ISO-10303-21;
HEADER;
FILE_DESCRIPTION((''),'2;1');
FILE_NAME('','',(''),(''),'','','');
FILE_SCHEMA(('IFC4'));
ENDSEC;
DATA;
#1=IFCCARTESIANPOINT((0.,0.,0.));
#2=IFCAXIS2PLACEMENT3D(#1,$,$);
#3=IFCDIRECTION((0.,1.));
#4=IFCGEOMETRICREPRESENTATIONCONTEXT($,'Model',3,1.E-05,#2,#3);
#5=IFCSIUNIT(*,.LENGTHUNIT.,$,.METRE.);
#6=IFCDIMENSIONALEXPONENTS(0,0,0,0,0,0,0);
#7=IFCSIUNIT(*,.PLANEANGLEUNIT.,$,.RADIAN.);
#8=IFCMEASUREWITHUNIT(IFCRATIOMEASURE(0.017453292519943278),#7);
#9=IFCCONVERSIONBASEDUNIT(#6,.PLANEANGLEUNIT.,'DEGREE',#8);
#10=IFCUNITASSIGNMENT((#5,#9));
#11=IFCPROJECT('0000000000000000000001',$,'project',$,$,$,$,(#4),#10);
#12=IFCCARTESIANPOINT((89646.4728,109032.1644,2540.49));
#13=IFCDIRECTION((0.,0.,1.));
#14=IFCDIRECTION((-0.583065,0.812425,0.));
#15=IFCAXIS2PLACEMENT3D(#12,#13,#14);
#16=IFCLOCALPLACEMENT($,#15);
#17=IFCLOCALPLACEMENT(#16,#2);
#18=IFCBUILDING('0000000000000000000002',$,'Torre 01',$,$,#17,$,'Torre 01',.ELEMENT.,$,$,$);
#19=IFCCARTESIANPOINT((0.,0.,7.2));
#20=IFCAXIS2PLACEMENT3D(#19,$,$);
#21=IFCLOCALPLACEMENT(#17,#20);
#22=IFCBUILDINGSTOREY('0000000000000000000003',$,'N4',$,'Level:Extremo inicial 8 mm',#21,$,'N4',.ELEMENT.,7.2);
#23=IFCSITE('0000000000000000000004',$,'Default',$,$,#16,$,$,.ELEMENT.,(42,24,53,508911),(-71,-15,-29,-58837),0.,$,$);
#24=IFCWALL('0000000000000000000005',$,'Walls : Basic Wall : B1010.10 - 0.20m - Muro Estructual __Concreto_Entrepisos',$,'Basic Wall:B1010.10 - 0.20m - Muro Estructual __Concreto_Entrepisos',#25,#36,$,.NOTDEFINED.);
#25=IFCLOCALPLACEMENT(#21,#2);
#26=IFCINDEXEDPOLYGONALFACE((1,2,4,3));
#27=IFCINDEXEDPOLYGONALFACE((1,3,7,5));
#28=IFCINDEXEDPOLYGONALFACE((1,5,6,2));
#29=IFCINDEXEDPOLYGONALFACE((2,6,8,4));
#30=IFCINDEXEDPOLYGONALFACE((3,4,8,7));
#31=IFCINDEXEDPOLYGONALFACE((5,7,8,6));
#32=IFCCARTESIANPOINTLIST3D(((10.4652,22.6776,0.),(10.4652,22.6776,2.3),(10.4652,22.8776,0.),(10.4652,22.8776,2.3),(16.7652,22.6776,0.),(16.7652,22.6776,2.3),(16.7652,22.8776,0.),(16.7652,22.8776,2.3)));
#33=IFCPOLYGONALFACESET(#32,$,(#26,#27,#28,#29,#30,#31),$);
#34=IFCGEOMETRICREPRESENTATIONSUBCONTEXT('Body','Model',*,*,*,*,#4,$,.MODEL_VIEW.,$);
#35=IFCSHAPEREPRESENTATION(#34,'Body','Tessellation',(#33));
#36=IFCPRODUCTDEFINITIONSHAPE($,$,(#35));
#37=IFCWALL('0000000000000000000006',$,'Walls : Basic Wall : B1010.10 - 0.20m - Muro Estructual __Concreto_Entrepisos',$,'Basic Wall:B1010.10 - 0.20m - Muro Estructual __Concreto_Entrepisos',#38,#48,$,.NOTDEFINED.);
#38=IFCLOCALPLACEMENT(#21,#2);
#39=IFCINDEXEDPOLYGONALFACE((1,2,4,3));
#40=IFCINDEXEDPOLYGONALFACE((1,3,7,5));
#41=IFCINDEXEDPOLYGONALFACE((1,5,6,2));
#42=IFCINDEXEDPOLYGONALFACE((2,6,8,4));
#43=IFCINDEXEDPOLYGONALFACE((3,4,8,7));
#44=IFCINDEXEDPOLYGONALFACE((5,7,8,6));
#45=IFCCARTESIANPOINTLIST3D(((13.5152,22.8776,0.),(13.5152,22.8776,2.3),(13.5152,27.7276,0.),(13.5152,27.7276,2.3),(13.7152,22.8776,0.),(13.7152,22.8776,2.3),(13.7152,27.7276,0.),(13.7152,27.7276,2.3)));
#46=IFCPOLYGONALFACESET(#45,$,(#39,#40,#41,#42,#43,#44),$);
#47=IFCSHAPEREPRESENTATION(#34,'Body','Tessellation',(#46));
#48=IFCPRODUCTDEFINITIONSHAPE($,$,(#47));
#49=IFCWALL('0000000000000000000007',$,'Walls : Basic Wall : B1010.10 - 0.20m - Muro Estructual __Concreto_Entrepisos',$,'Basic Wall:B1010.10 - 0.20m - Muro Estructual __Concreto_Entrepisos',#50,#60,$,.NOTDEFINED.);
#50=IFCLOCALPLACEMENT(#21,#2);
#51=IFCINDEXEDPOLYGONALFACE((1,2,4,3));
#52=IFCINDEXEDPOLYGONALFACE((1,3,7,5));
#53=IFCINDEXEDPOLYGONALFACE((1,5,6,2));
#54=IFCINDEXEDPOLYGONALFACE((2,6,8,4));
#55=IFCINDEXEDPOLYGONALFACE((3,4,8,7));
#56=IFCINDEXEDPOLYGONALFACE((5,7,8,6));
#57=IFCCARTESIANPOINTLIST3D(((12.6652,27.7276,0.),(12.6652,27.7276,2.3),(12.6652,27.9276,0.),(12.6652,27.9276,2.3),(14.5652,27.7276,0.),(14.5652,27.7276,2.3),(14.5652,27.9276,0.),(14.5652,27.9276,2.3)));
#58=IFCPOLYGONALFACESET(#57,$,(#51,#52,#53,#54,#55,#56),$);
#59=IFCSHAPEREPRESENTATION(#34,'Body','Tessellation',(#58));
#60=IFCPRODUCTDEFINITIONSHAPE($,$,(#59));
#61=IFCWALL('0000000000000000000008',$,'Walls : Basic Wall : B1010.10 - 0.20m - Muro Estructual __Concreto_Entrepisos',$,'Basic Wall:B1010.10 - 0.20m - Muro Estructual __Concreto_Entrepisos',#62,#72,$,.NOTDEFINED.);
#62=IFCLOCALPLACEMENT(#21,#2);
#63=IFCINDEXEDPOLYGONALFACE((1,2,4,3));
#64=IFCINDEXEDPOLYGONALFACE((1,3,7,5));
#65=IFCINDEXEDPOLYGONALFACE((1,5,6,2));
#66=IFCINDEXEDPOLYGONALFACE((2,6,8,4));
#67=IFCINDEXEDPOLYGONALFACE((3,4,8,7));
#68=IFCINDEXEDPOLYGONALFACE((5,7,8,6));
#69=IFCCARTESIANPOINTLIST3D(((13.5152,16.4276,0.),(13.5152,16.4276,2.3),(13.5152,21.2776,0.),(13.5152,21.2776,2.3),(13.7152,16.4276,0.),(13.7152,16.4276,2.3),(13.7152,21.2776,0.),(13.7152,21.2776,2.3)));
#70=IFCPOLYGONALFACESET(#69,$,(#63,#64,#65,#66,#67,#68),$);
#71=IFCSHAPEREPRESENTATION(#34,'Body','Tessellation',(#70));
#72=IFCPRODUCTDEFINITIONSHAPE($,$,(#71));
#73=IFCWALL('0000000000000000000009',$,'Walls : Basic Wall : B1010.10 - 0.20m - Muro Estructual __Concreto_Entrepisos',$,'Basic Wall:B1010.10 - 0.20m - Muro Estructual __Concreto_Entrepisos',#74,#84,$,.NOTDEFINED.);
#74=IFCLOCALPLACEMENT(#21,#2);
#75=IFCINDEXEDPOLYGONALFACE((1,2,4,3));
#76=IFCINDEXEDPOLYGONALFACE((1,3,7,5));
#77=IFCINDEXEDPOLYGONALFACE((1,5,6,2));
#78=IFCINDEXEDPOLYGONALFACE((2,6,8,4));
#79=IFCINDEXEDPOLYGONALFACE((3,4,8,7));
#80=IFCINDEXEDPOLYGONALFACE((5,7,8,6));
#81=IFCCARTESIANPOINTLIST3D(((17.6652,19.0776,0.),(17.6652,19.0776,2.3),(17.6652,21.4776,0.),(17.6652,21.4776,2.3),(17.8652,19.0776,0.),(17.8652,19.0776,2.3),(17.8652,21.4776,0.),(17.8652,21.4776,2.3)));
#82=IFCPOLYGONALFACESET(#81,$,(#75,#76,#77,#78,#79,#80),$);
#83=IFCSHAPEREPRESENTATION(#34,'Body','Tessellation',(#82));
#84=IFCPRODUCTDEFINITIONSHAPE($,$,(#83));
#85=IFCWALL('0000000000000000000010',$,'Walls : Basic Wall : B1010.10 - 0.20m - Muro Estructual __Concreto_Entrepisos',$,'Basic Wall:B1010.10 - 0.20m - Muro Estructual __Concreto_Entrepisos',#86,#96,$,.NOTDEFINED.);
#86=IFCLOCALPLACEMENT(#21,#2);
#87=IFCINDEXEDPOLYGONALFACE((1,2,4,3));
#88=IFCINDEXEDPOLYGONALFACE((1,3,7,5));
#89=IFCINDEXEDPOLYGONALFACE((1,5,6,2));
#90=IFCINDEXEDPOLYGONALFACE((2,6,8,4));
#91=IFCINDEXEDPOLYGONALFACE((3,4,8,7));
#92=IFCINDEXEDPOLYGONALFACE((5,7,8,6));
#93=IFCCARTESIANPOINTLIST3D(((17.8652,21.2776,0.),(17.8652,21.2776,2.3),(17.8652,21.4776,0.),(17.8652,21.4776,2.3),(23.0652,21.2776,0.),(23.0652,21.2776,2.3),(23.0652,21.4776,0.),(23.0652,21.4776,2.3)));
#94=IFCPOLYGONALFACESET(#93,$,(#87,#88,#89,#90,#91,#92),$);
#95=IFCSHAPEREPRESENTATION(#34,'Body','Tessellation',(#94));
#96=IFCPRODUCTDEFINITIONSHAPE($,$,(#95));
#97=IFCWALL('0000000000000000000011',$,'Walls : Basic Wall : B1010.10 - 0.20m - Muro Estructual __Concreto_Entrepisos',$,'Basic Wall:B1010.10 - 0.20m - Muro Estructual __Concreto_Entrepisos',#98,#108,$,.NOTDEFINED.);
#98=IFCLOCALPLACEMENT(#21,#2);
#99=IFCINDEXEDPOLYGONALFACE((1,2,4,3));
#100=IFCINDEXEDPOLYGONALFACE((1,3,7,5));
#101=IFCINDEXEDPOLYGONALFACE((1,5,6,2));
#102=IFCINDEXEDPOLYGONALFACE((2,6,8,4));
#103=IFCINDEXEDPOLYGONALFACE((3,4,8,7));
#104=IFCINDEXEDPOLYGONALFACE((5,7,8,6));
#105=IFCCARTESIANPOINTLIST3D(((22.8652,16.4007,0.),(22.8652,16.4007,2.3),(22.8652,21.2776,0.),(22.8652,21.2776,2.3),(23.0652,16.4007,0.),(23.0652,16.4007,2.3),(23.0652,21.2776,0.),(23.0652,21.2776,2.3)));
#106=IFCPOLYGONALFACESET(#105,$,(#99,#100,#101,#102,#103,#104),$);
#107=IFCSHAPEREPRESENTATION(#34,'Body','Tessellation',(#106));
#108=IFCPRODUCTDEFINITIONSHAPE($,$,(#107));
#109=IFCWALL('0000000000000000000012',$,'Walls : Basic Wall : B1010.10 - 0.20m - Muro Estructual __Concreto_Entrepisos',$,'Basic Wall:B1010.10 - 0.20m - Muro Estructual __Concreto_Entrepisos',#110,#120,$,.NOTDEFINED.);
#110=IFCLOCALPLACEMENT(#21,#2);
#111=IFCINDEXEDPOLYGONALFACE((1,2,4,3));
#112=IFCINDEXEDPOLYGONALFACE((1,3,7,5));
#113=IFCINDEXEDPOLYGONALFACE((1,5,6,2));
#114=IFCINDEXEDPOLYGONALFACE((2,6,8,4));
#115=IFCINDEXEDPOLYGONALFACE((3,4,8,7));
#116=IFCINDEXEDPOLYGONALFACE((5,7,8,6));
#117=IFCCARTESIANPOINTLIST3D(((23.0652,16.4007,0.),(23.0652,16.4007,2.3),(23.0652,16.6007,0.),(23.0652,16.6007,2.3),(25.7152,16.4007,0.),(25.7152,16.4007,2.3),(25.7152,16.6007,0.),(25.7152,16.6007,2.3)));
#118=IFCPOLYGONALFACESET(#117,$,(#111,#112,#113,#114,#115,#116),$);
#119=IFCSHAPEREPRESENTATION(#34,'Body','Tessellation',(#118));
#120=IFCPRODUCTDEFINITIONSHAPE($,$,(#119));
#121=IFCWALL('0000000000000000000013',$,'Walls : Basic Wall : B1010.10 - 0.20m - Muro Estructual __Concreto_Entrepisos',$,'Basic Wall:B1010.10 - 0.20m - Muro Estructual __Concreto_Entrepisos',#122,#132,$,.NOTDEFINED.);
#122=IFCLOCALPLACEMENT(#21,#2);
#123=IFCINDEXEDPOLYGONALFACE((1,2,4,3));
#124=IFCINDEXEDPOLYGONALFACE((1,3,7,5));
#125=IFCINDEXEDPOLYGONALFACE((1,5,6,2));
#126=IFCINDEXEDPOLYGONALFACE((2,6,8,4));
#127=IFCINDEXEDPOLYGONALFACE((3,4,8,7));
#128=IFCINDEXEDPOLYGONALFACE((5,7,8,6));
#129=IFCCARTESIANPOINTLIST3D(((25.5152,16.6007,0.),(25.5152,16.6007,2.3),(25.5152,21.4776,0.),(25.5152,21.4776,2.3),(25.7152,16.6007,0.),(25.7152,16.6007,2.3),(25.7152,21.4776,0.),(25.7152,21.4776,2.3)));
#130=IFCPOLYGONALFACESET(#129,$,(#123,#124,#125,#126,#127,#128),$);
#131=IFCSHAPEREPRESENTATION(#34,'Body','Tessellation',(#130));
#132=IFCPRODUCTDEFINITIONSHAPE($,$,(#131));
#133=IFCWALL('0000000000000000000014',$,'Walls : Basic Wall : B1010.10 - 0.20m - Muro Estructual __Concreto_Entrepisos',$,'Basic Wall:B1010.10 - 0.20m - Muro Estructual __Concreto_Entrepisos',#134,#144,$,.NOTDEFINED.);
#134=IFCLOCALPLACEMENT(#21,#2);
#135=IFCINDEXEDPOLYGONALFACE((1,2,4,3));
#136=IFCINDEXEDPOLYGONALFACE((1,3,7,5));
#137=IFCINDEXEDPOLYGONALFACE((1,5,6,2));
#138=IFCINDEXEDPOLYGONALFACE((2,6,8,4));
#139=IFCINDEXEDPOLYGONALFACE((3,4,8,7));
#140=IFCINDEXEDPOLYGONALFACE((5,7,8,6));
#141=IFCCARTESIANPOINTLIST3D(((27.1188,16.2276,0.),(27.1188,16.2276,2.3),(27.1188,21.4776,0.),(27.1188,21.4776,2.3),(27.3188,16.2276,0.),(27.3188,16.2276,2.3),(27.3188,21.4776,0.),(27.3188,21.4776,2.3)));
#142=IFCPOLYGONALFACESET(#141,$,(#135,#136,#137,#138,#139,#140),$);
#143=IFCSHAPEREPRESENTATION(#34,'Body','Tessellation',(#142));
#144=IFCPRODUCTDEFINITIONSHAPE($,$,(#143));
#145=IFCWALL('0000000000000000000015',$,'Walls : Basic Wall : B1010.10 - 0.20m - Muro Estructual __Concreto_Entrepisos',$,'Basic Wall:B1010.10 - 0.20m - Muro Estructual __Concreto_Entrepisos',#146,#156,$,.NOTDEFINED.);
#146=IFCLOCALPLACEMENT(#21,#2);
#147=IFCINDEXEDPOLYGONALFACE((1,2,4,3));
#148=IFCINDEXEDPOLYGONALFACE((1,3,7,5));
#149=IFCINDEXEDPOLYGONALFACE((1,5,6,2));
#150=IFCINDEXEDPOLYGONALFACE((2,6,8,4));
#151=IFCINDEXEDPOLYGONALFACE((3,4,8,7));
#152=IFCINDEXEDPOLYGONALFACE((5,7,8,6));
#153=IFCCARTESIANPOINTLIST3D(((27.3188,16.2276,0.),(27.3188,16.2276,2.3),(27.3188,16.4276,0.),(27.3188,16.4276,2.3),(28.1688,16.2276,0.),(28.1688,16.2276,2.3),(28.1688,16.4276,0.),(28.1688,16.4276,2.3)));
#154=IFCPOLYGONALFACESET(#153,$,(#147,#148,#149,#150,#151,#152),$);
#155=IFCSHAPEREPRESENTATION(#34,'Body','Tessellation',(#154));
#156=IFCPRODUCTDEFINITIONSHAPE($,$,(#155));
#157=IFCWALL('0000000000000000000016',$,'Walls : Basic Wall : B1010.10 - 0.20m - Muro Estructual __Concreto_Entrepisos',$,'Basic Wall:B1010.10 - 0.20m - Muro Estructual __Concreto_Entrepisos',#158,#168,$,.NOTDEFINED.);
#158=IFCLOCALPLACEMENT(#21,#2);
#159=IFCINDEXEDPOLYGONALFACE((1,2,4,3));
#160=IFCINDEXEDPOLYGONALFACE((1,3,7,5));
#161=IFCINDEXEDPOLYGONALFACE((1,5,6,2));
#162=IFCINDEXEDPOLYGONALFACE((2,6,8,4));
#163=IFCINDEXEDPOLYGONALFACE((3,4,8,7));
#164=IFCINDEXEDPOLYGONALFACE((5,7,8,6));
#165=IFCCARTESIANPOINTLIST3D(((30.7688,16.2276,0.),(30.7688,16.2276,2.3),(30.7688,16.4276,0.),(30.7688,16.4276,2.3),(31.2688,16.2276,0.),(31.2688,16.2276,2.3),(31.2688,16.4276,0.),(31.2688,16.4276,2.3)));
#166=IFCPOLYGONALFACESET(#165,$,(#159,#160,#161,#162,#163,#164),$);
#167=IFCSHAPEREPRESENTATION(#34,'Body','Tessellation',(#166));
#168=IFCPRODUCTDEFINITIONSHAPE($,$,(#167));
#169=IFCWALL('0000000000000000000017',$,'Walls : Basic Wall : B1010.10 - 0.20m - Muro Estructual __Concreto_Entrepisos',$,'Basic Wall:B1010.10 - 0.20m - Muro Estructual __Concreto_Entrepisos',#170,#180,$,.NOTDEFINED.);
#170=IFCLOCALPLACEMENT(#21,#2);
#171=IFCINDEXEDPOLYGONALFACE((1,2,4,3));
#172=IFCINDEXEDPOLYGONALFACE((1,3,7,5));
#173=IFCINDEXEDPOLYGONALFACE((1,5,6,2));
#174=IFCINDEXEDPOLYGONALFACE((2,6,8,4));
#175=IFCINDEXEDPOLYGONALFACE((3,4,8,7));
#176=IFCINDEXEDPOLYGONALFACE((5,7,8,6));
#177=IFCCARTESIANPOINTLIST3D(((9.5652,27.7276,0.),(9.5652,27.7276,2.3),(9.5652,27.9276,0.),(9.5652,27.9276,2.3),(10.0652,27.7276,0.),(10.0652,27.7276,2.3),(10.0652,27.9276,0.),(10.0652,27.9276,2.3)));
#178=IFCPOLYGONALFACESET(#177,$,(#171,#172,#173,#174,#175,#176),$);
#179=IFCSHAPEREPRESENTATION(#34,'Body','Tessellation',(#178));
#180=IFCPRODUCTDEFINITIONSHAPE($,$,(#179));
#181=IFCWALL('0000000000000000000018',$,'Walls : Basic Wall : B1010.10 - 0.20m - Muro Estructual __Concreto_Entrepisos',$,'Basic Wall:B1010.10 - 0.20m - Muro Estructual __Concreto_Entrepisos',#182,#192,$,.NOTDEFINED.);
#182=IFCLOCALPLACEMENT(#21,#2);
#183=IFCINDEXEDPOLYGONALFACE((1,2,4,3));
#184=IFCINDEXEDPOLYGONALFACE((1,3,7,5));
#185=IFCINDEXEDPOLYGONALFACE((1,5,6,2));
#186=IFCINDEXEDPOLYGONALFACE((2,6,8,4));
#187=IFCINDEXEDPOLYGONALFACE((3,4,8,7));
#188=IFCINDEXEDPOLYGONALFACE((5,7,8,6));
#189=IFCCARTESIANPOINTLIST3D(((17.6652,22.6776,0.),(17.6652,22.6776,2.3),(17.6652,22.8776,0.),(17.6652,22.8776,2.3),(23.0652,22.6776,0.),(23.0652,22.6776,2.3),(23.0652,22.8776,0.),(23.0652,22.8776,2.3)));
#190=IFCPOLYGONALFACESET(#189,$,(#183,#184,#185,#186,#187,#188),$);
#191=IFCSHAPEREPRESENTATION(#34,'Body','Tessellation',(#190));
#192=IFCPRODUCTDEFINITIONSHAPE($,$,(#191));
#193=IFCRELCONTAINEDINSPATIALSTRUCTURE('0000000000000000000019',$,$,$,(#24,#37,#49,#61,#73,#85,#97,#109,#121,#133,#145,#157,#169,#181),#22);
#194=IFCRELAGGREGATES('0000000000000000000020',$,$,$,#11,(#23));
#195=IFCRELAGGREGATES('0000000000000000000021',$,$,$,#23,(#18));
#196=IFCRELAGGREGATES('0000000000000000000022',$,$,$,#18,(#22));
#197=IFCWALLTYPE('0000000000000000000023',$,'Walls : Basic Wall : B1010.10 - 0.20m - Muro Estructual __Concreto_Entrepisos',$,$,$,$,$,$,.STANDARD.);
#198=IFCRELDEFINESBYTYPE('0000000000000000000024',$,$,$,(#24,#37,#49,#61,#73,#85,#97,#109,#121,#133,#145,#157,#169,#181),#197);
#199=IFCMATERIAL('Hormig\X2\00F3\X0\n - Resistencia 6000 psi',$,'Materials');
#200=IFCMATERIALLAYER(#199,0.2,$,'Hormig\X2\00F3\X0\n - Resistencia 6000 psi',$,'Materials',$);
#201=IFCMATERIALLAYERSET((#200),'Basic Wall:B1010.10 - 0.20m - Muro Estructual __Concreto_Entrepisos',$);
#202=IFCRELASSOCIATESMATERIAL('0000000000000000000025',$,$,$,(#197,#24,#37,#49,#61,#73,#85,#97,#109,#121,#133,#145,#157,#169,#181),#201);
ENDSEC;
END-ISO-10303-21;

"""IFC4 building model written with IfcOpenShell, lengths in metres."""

from ifc_helpers import new_model, entity, si_unit, converted_unit, direction, frame, frame_2d, origin, place, context, subcontext, project, spatial, rectangle, extrude, material, layer, layer_set, layer_usage, type_object, element, save


model = new_model("IFC4")

# Units and contexts
model_context = context("Model", 3, precision=1e-05, world=origin(), true_north=direction((0.0, 1.0)))
body_context = subcontext(model_context, "Body", "Model", "MODEL_VIEW")
ifc_project = project(units=[si_unit("LENGTHUNIT", "METRE"), converted_unit("PLANEANGLEUNIT", "DEGREE", entity("IfcRatioMeasure", 0.017453292519943278), si_unit("PLANEANGLEUNIT", "RADIAN"), dimensions=[0, 0, 0, 0, 0, 0, 0])], contexts=[model_context])

# Site, building, storey
site_placement = place(None, frame((89646.4728, 109032.1644, 2540.49), z_axis=(0.0, 0.0, 1.0), x_axis=(-0.583065, 0.812425, 0.0)))
site = spatial("IfcSite", under=ifc_project, at=site_placement, Name="Default", CompositionType="ELEMENT", RefLatitude=(42, 24, 53, 508911), RefLongitude=(-71, -15, -29, -58837), RefElevation=0.0)
building_placement = place(site_placement, origin())
building = spatial("IfcBuilding", under=site, at=building_placement, Name="Torre 01", LongName="Torre 01", CompositionType="ELEMENT")
storey_placement = place(building_placement, frame((0.0, 0.0, 7.2)))
storey = spatial("IfcBuildingStorey", under=building, at=storey_placement, Name="N4", ObjectType="Level:Extremo inicial 8 mm", LongName="N4", CompositionType="ELEMENT", Elevation=7.2)

# Walls
ifc_material = material(Name="Hormigón - Resistencia 6000 psi", Category="Materials")
ifc_layer_1 = layer(ifc_material, 0.2, Name="Hormigón - Resistencia 6000 psi", Category="Materials")
ifc_layer_set_1 = layer_set([ifc_layer_1], Name="Basic Wall:B1010.10 - 0.20m - Muro Estructual __Concreto_Entrepisos")
ifc_layer_usage_1 = layer_usage(ifc_layer_set_1, "AXIS2", "NEGATIVE", 0.1)
wall_type_1 = type_object("IfcWallType", Name="Walls : Basic Wall : B1010.10 - 0.20m - Muro Estructual __Concreto_Entrepisos", PredefinedType="STANDARD", material=ifc_layer_set_1)
wall_1_placement = place(storey_placement, frame((10.4652, 22.7776, 0.0)))
element("IfcWall", 1, at=wall_1_placement, inside=storey, type_object=wall_type_1, material=ifc_layer_usage_1, Name="Walls : Basic Wall : B1010.10 - 0.20m - Muro Estructual __Concreto_Entrepisos", ObjectType="Basic Wall:B1010.10 - 0.20m - Muro Estructual __Concreto_Entrepisos", PredefinedType="NOTDEFINED", context=body_context, shape_type="SweptSolid", body=[
    extrude(rectangle(XDim=6.3, YDim=0.2, at=frame_2d((3.15, 0.0), x_axis=(-1.0, 0.0))), origin(), (0.0, 0.0, 1.0), 2.3),
])
ifc_layer_usage_2 = layer_usage(ifc_layer_set_1, "AXIS2", "NEGATIVE", 0.1)
wall_2_placement = place(storey_placement, frame((13.6152, 22.8776, 0.0), z_axis=(0.0, 0.0, 1.0), x_axis=(0.0, 1.0, 0.0)))
element("IfcWall", 2, at=wall_2_placement, inside=storey, type_object=wall_type_1, material=ifc_layer_usage_2, Name="Walls : Basic Wall : B1010.10 - 0.20m - Muro Estructual __Concreto_Entrepisos", ObjectType="Basic Wall:B1010.10 - 0.20m - Muro Estructual __Concreto_Entrepisos", PredefinedType="NOTDEFINED", context=body_context, shape_type="SweptSolid", body=[
    extrude(rectangle(XDim=4.85, YDim=0.2, at=frame_2d((2.425, 0.0), x_axis=(-1.0, 0.0))), origin(), (0.0, 0.0, 1.0), 2.3),
])
ifc_layer_usage_3 = layer_usage(ifc_layer_set_1, "AXIS2", "NEGATIVE", 0.1)
wall_3_placement = place(storey_placement, frame((12.6652, 27.8276, 0.0)))
element("IfcWall", 3, at=wall_3_placement, inside=storey, type_object=wall_type_1, material=ifc_layer_usage_3, Name="Walls : Basic Wall : B1010.10 - 0.20m - Muro Estructual __Concreto_Entrepisos", ObjectType="Basic Wall:B1010.10 - 0.20m - Muro Estructual __Concreto_Entrepisos", PredefinedType="NOTDEFINED", context=body_context, shape_type="SweptSolid", body=[
    extrude(rectangle(XDim=1.9, YDim=0.2, at=frame_2d((0.95, 0.0), x_axis=(-1.0, 0.0))), origin(), (0.0, 0.0, 1.0), 2.3),
])
ifc_layer_usage_4 = layer_usage(ifc_layer_set_1, "AXIS2", "NEGATIVE", 0.1)
wall_4_placement = place(storey_placement, frame((13.6152, 21.2776, 0.0), z_axis=(0.0, 0.0, 1.0), x_axis=(0.0, -1.0, 0.0)))
element("IfcWall", 4, at=wall_4_placement, inside=storey, type_object=wall_type_1, material=ifc_layer_usage_4, Name="Walls : Basic Wall : B1010.10 - 0.20m - Muro Estructual __Concreto_Entrepisos", ObjectType="Basic Wall:B1010.10 - 0.20m - Muro Estructual __Concreto_Entrepisos", PredefinedType="NOTDEFINED", context=body_context, shape_type="SweptSolid", body=[
    extrude(rectangle(XDim=4.85, YDim=0.2, at=frame_2d((2.425, 0.0), x_axis=(-1.0, 0.0))), origin(), (0.0, 0.0, 1.0), 2.3),
])
ifc_layer_usage_5 = layer_usage(ifc_layer_set_1, "AXIS2", "NEGATIVE", 0.1)
wall_5_placement = place(storey_placement, frame((17.7652, 19.0776, 0.0), z_axis=(0.0, 0.0, 1.0), x_axis=(0.0, 1.0, 0.0)))
element("IfcWall", 5, at=wall_5_placement, inside=storey, type_object=wall_type_1, material=ifc_layer_usage_5, Name="Walls : Basic Wall : B1010.10 - 0.20m - Muro Estructual __Concreto_Entrepisos", ObjectType="Basic Wall:B1010.10 - 0.20m - Muro Estructual __Concreto_Entrepisos", PredefinedType="NOTDEFINED", context=body_context, shape_type="SweptSolid", body=[
    extrude(rectangle(XDim=2.4, YDim=0.2, at=frame_2d((1.2, 0.0), x_axis=(-1.0, 0.0))), origin(), (0.0, 0.0, 1.0), 2.3),
])
ifc_layer_usage_6 = layer_usage(ifc_layer_set_1, "AXIS2", "NEGATIVE", 0.1)
wall_6_placement = place(storey_placement, frame((17.8652, 21.3776, 0.0)))
element("IfcWall", 6, at=wall_6_placement, inside=storey, type_object=wall_type_1, material=ifc_layer_usage_6, Name="Walls : Basic Wall : B1010.10 - 0.20m - Muro Estructual __Concreto_Entrepisos", ObjectType="Basic Wall:B1010.10 - 0.20m - Muro Estructual __Concreto_Entrepisos", PredefinedType="NOTDEFINED", context=body_context, shape_type="SweptSolid", body=[
    extrude(rectangle(XDim=5.2, YDim=0.2, at=frame_2d((2.6, 0.0), x_axis=(-1.0, 0.0))), origin(), (0.0, 0.0, 1.0), 2.3),
])
ifc_layer_usage_7 = layer_usage(ifc_layer_set_1, "AXIS2", "NEGATIVE", 0.1)
wall_7_placement = place(storey_placement, frame((22.9652, 21.2776, 0.0), z_axis=(0.0, 0.0, 1.0), x_axis=(0.0, -1.0, 0.0)))
element("IfcWall", 7, at=wall_7_placement, inside=storey, type_object=wall_type_1, material=ifc_layer_usage_7, Name="Walls : Basic Wall : B1010.10 - 0.20m - Muro Estructual __Concreto_Entrepisos", ObjectType="Basic Wall:B1010.10 - 0.20m - Muro Estructual __Concreto_Entrepisos", PredefinedType="NOTDEFINED", context=body_context, shape_type="SweptSolid", body=[
    extrude(rectangle(XDim=4.8769, YDim=0.2, at=frame_2d((2.4384, 0.0), x_axis=(-1.0, 0.0))), origin(), (0.0, 0.0, 1.0), 2.3),
])
ifc_layer_usage_8 = layer_usage(ifc_layer_set_1, "AXIS2", "NEGATIVE", 0.1)
wall_8_placement = place(storey_placement, frame((23.0652, 16.5007, 0.0)))
element("IfcWall", 8, at=wall_8_placement, inside=storey, type_object=wall_type_1, material=ifc_layer_usage_8, Name="Walls : Basic Wall : B1010.10 - 0.20m - Muro Estructual __Concreto_Entrepisos", ObjectType="Basic Wall:B1010.10 - 0.20m - Muro Estructual __Concreto_Entrepisos", PredefinedType="NOTDEFINED", context=body_context, shape_type="SweptSolid", body=[
    extrude(rectangle(XDim=2.65, YDim=0.2, at=frame_2d((1.325, 0.0), x_axis=(-1.0, 0.0))), origin(), (0.0, 0.0, 1.0), 2.3),
])
ifc_layer_usage_9 = layer_usage(ifc_layer_set_1, "AXIS2", "NEGATIVE", 0.1)
wall_9_placement = place(storey_placement, frame((25.6152, 16.6007, 0.0), z_axis=(0.0, 0.0, 1.0), x_axis=(0.0, 1.0, 0.0)))
element("IfcWall", 9, at=wall_9_placement, inside=storey, type_object=wall_type_1, material=ifc_layer_usage_9, Name="Walls : Basic Wall : B1010.10 - 0.20m - Muro Estructual __Concreto_Entrepisos", ObjectType="Basic Wall:B1010.10 - 0.20m - Muro Estructual __Concreto_Entrepisos", PredefinedType="NOTDEFINED", context=body_context, shape_type="SweptSolid", body=[
    extrude(rectangle(XDim=4.8769, YDim=0.2, at=frame_2d((2.4384, 0.0), x_axis=(-1.0, 0.0))), origin(), (0.0, 0.0, 1.0), 2.3),
])
ifc_layer_usage_10 = layer_usage(ifc_layer_set_1, "AXIS2", "NEGATIVE", 0.1)
wall_10_placement = place(storey_placement, frame((27.2188, 16.2276, 0.0), z_axis=(0.0, 0.0, 1.0), x_axis=(0.0, 1.0, 0.0)))
element("IfcWall", 10, at=wall_10_placement, inside=storey, type_object=wall_type_1, material=ifc_layer_usage_10, Name="Walls : Basic Wall : B1010.10 - 0.20m - Muro Estructual __Concreto_Entrepisos", ObjectType="Basic Wall:B1010.10 - 0.20m - Muro Estructual __Concreto_Entrepisos", PredefinedType="NOTDEFINED", context=body_context, shape_type="SweptSolid", body=[
    extrude(rectangle(XDim=5.25, YDim=0.2, at=frame_2d((2.625, 0.0), x_axis=(-1.0, 0.0))), origin(), (0.0, 0.0, 1.0), 2.3),
])
ifc_layer_usage_11 = layer_usage(ifc_layer_set_1, "AXIS2", "NEGATIVE", 0.1)
wall_11_placement = place(storey_placement, frame((27.3188, 16.3276, 0.0)))
element("IfcWall", 11, at=wall_11_placement, inside=storey, type_object=wall_type_1, material=ifc_layer_usage_11, Name="Walls : Basic Wall : B1010.10 - 0.20m - Muro Estructual __Concreto_Entrepisos", ObjectType="Basic Wall:B1010.10 - 0.20m - Muro Estructual __Concreto_Entrepisos", PredefinedType="NOTDEFINED", context=body_context, shape_type="SweptSolid", body=[
    extrude(rectangle(XDim=0.85, YDim=0.2, at=frame_2d((0.425, 0.0), x_axis=(-1.0, 0.0))), origin(), (0.0, 0.0, 1.0), 2.3),
])
ifc_layer_usage_12 = layer_usage(ifc_layer_set_1, "AXIS2", "NEGATIVE", 0.1)
wall_12_placement = place(storey_placement, frame((30.7688, 16.3276, 0.0)))
element("IfcWall", 12, at=wall_12_placement, inside=storey, type_object=wall_type_1, material=ifc_layer_usage_12, Name="Walls : Basic Wall : B1010.10 - 0.20m - Muro Estructual __Concreto_Entrepisos", ObjectType="Basic Wall:B1010.10 - 0.20m - Muro Estructual __Concreto_Entrepisos", PredefinedType="NOTDEFINED", context=body_context, shape_type="SweptSolid", body=[
    extrude(rectangle(XDim=0.5, YDim=0.2, at=frame_2d((0.25, 0.0), x_axis=(-1.0, 0.0))), origin(), (0.0, 0.0, 1.0), 2.3),
])
ifc_layer_usage_13 = layer_usage(ifc_layer_set_1, "AXIS2", "NEGATIVE", 0.1)
wall_13_placement = place(storey_placement, frame((9.5652, 27.8276, 0.0)))
element("IfcWall", 13, at=wall_13_placement, inside=storey, type_object=wall_type_1, material=ifc_layer_usage_13, Name="Walls : Basic Wall : B1010.10 - 0.20m - Muro Estructual __Concreto_Entrepisos", ObjectType="Basic Wall:B1010.10 - 0.20m - Muro Estructual __Concreto_Entrepisos", PredefinedType="NOTDEFINED", context=body_context, shape_type="SweptSolid", body=[
    extrude(rectangle(XDim=0.5, YDim=0.2, at=frame_2d((0.25, 0.0), x_axis=(-1.0, 0.0))), origin(), (0.0, 0.0, 1.0), 2.3),
])
ifc_layer_usage_14 = layer_usage(ifc_layer_set_1, "AXIS2", "NEGATIVE", 0.1)
wall_14_placement = place(storey_placement, frame((17.6652, 22.7776, 0.0)))
element("IfcWall", 14, at=wall_14_placement, inside=storey, type_object=wall_type_1, material=ifc_layer_usage_14, Name="Walls : Basic Wall : B1010.10 - 0.20m - Muro Estructual __Concreto_Entrepisos", ObjectType="Basic Wall:B1010.10 - 0.20m - Muro Estructual __Concreto_Entrepisos", PredefinedType="NOTDEFINED", context=body_context, shape_type="SweptSolid", body=[
    extrude(rectangle(XDim=5.4, YDim=0.2, at=frame_2d((2.7, 0.0), x_axis=(-1.0, 0.0))), origin(), (0.0, 0.0, 1.0), 2.3),
])

save(model, "model.ifc")
